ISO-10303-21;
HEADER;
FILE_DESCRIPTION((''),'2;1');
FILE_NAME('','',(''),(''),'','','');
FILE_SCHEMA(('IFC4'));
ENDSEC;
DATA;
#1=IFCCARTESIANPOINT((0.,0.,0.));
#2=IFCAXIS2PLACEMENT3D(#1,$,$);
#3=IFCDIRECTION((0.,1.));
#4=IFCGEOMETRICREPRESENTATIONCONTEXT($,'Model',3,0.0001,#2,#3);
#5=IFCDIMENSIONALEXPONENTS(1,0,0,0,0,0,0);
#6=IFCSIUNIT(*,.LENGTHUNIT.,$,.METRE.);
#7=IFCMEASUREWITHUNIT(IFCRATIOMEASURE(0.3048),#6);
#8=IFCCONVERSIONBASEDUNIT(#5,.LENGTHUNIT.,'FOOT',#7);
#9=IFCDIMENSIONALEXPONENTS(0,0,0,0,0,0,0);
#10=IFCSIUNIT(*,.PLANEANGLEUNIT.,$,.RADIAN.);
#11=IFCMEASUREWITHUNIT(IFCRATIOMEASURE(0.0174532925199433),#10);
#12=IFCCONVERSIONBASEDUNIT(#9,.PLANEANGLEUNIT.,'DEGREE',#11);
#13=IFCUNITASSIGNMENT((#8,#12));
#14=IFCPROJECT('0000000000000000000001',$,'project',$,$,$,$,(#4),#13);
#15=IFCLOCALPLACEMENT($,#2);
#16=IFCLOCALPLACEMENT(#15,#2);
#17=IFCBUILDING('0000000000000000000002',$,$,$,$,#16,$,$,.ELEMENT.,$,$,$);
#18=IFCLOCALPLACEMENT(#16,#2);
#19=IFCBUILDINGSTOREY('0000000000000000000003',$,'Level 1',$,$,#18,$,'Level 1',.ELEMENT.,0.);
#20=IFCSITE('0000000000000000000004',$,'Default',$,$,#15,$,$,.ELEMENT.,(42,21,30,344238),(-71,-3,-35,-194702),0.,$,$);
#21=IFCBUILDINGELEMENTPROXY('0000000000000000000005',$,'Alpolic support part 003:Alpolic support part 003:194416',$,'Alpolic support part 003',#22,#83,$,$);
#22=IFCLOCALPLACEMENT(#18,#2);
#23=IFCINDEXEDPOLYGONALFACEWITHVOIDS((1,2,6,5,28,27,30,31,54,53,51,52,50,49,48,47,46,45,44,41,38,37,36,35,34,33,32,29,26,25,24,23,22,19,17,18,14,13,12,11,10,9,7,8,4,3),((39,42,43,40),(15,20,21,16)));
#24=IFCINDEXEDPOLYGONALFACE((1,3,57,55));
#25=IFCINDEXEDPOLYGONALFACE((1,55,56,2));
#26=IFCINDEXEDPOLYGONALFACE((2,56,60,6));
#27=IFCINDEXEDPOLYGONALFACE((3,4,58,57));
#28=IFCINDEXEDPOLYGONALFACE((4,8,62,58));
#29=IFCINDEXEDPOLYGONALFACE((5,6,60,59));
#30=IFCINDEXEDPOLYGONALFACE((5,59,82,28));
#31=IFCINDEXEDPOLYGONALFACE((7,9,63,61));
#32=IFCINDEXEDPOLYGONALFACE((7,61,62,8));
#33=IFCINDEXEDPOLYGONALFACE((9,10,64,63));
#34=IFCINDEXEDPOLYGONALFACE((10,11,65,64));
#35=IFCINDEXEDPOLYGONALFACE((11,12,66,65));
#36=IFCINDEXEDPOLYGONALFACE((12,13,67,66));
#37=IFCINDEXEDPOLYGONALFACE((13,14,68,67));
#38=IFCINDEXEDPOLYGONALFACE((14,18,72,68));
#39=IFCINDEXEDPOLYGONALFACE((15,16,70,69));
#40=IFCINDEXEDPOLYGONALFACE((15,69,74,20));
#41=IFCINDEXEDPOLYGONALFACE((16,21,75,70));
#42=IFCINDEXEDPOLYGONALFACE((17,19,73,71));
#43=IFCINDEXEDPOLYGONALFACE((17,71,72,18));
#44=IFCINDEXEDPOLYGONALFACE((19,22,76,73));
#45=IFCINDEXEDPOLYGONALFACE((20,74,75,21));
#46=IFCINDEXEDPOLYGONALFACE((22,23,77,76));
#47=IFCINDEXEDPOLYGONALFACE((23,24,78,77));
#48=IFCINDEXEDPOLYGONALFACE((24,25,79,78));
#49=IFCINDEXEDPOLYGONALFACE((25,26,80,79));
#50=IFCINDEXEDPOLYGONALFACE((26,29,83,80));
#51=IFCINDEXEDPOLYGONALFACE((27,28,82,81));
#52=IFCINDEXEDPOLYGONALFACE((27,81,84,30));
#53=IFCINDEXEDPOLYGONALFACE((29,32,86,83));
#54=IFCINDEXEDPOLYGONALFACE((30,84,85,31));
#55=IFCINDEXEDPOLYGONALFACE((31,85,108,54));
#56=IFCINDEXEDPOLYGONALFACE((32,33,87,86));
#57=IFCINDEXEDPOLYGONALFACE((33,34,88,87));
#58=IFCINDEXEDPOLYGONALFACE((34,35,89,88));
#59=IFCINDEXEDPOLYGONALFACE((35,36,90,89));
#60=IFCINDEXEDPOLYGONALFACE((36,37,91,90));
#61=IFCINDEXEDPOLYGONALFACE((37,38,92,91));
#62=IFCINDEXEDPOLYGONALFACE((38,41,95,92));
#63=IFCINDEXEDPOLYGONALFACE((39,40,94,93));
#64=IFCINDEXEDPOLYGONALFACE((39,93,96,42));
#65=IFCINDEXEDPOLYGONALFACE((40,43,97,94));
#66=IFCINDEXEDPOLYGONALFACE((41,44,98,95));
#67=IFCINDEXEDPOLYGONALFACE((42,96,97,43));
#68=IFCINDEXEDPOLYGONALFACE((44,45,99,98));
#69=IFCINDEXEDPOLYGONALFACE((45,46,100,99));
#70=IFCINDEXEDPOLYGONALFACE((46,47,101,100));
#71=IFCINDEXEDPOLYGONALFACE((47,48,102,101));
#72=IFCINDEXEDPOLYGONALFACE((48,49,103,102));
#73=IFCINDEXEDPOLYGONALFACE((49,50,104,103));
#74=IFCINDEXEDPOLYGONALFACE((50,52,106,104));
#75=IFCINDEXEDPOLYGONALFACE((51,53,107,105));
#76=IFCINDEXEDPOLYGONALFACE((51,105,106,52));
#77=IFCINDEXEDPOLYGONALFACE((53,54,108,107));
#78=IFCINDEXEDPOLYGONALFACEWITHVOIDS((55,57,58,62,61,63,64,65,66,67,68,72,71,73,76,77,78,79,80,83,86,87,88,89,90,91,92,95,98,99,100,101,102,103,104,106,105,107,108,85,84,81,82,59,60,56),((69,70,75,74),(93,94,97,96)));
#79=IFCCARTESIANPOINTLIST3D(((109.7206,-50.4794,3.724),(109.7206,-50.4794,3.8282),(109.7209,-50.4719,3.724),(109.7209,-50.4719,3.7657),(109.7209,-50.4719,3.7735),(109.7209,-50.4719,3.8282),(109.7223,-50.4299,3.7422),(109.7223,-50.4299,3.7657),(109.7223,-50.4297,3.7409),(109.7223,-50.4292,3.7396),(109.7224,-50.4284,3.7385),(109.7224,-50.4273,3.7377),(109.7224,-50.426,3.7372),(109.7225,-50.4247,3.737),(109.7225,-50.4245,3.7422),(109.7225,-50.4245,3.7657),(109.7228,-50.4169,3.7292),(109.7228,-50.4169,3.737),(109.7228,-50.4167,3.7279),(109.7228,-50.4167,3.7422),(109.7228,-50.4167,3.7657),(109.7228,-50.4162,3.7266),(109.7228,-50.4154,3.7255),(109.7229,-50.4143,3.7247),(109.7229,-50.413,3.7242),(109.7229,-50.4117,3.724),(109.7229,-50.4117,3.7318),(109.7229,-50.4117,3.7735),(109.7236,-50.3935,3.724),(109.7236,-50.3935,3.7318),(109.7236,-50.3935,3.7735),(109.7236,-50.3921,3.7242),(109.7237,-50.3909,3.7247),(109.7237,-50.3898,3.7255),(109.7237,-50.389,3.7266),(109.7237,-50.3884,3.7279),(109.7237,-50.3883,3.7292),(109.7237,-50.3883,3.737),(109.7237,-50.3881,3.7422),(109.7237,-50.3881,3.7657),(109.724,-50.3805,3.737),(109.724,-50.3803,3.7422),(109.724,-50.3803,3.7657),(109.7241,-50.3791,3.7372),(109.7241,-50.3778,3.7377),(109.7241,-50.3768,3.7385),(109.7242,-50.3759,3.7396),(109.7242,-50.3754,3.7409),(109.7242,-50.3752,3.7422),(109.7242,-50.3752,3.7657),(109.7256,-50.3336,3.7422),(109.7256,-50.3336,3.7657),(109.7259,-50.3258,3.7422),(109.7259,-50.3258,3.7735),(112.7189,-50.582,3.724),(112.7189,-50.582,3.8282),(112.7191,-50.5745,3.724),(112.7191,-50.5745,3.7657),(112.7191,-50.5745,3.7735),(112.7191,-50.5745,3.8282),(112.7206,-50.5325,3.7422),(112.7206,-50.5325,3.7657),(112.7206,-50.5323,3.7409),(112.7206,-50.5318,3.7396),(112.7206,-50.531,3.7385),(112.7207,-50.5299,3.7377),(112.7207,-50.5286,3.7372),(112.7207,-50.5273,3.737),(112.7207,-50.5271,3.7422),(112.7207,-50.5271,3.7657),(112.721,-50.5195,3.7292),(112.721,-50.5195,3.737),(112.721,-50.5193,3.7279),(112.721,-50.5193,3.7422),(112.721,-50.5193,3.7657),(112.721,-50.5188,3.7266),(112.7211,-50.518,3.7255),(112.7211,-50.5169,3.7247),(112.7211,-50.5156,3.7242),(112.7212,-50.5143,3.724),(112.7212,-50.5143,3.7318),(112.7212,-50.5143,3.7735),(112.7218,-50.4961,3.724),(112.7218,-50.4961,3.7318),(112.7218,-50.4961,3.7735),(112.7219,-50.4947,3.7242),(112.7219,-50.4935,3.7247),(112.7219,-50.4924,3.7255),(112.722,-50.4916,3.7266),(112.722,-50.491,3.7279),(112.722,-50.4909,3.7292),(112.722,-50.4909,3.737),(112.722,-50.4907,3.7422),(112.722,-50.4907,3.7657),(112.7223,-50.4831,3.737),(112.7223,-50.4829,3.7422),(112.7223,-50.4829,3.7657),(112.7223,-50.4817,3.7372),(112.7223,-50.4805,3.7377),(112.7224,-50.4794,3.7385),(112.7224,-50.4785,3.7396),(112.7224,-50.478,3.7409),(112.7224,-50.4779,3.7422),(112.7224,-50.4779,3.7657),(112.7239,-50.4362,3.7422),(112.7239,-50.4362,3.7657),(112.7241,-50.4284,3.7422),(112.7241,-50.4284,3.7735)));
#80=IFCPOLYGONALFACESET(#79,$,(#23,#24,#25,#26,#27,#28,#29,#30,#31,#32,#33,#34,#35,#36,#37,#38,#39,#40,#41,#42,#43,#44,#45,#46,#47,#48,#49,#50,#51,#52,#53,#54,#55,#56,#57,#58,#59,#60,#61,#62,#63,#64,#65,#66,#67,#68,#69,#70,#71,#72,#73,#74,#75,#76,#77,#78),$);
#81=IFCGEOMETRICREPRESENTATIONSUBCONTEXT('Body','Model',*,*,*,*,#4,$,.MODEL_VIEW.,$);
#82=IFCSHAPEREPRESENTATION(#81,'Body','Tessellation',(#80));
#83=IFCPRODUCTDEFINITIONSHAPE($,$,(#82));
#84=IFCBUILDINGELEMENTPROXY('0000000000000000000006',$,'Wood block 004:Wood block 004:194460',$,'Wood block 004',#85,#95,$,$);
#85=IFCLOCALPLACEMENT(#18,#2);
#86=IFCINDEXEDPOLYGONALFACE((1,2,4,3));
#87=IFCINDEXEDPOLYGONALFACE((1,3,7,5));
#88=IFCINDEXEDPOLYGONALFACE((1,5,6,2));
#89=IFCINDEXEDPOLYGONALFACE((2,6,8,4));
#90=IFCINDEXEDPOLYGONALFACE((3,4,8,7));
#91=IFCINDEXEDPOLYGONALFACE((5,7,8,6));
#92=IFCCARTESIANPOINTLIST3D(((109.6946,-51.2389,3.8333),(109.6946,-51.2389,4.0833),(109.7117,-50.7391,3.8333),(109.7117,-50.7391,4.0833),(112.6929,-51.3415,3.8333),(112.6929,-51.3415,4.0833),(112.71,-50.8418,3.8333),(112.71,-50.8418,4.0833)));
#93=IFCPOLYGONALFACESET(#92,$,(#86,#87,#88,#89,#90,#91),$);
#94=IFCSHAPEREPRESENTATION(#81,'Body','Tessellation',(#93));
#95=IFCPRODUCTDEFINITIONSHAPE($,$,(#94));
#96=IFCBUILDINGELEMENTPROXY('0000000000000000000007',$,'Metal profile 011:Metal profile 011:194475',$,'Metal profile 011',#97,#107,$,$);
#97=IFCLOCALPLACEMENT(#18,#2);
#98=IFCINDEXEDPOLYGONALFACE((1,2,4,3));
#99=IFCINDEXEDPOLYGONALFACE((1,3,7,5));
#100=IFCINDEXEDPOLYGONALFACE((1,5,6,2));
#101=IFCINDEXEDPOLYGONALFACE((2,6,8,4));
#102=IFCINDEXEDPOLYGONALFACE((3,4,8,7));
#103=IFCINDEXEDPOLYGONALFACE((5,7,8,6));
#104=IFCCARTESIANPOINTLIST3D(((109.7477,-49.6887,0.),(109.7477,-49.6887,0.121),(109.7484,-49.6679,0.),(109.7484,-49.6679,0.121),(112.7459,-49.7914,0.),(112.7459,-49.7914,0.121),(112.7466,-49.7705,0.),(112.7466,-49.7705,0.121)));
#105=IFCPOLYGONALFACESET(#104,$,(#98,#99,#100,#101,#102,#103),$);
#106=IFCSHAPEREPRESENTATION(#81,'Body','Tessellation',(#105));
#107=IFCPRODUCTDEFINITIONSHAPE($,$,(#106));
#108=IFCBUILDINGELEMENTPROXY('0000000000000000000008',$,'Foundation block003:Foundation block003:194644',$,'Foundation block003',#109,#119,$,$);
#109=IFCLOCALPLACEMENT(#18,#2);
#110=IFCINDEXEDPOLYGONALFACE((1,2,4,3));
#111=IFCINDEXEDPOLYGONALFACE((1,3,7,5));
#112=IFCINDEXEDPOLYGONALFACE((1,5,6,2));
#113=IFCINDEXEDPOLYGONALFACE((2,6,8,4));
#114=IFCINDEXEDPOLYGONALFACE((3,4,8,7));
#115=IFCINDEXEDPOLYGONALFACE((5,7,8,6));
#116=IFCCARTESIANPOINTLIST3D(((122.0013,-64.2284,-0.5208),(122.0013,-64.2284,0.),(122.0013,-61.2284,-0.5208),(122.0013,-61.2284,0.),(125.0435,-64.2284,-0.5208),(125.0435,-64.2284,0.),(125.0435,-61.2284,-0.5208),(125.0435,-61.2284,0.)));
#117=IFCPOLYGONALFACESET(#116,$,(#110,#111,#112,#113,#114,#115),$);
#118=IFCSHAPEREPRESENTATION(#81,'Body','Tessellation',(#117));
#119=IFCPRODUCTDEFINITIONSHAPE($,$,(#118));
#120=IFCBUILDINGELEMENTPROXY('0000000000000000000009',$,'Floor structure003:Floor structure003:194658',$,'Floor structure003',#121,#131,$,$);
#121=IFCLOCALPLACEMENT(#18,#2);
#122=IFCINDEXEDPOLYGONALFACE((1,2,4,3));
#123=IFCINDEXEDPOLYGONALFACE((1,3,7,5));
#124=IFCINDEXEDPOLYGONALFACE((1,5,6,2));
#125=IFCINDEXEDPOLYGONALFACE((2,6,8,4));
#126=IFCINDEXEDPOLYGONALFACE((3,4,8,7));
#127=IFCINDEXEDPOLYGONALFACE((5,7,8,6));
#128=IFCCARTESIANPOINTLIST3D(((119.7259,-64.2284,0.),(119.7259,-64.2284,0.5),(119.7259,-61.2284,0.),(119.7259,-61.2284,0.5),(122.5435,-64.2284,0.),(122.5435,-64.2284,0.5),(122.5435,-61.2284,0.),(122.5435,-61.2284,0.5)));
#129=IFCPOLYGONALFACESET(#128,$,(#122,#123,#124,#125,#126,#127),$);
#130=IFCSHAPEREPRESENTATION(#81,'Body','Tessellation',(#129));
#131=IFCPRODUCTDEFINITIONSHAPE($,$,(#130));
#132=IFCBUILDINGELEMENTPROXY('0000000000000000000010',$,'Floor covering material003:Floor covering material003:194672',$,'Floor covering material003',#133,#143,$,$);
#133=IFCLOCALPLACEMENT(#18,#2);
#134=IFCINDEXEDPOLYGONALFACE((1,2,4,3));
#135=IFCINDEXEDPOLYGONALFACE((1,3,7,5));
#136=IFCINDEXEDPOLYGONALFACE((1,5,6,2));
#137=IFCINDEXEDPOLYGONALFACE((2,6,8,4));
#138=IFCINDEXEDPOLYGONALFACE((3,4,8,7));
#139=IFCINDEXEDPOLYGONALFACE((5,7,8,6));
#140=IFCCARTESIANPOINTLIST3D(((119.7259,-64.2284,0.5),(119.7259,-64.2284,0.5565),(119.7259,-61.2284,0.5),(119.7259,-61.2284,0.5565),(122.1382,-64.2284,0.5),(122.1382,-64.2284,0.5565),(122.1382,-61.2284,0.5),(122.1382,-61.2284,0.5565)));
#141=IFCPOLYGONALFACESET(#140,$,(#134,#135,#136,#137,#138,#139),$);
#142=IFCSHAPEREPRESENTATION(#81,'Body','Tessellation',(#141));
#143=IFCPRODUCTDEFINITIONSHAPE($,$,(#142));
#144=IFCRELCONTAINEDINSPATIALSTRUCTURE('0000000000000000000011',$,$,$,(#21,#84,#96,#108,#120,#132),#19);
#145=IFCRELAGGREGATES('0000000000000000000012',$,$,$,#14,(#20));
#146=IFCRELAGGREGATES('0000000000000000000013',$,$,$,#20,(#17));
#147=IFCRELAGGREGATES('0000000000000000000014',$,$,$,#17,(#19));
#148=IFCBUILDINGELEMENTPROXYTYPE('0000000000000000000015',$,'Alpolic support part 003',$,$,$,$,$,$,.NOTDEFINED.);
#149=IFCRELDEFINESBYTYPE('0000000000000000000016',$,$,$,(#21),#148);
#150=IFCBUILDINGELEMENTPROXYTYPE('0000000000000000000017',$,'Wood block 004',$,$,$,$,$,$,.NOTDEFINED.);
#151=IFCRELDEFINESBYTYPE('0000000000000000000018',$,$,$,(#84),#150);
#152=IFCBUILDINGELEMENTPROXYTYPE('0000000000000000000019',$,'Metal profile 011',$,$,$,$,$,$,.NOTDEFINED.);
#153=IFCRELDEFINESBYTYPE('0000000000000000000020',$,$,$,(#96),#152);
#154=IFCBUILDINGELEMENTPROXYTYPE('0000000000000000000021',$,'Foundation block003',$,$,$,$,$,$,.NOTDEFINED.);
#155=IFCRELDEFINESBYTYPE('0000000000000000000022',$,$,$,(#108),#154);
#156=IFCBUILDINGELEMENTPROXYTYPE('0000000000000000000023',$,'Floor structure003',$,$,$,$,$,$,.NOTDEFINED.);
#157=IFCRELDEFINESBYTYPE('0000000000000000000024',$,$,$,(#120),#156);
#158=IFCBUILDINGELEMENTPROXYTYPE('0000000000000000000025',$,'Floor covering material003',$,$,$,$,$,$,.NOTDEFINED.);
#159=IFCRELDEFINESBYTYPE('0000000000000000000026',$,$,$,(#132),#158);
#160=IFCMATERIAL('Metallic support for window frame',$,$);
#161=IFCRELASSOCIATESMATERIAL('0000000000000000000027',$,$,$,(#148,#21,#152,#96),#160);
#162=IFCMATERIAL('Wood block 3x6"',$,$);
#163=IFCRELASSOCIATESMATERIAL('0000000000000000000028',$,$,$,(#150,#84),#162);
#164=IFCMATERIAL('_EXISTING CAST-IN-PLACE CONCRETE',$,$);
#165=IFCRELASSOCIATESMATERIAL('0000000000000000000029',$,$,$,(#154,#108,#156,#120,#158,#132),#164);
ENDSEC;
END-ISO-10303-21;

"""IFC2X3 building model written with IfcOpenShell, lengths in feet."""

from ifc_helpers import new_model, entity, si_unit, converted_unit, direction, frame, frame_2d, origin, origin_2d_with_axis, place, context, subcontext, project, spatial, polyline, circle_curve, parameter, trimmed, segment, composite_curve, rectangle, outline, extrude, source, transform, mapped, material, type_object, type_shapes, element, save


model = new_model("IFC2X3")

# Units and contexts
model_context = context("Model", 3, precision=0.0001, world=origin(), true_north=direction((0.0, 1.0)))
body_context = subcontext(model_context, "Body", "Model", "MODEL_VIEW")
ifc_project = project(units=[converted_unit("LENGTHUNIT", "FOOT", entity("IfcRatioMeasure", 0.3048), si_unit("LENGTHUNIT", "METRE"), dimensions=[1, 0, 0, 0, 0, 0, 0]), converted_unit("PLANEANGLEUNIT", "DEGREE", entity("IfcRatioMeasure", 0.0174532925199433), si_unit("PLANEANGLEUNIT", "RADIAN"), dimensions=[0, 0, 0, 0, 0, 0, 0])], contexts=[model_context])

# Site, building, storey
site_placement = place(None, origin())
site = spatial("IfcSite", under=ifc_project, at=site_placement, Name="Default", CompositionType="ELEMENT", RefLatitude=(42, 21, 30, 344238), RefLongitude=(-71, -3, -35, -194702), RefElevation=0.0)
building_placement = place(site_placement, origin())
building = spatial("IfcBuilding", under=site, at=building_placement, CompositionType="ELEMENT")
storey_placement = place(building_placement, origin())
storey = spatial("IfcBuildingStorey", under=building, at=storey_placement, Name="Level 1", LongName="Level 1", CompositionType="ELEMENT", Elevation=0.0)

# Building element proxies
ifc_material_1 = material(Name="Metallic support for window frame")
building_element_proxy_type_1 = type_object("IfcBuildingElementProxyType", Name="Alpolic support part 003", PredefinedType="NOTDEFINED", material=ifc_material_1)
shared_shape_1 = source(origin(), body_context, "Body", "SweptSolid", [
    extrude(outline(composite_curve([segment(trimmed(circle_curve(frame_2d((-0.0096, 0.0275), x_axis=(0.0, -1.0)), 0.0052), [parameter(180.0)], [parameter(270.0)], True, "PARAMETER"), True, "CONTINUOUS"), segment(polyline([(-0.0148, 0.0275), (-0.0148, 0.0197)]), True, "CONTINUOUS"), segment(polyline([(-0.0148, 0.0197), (-0.0226, 0.0197)]), True, "CONTINUOUS"), segment(trimmed(circle_curve(frame_2d((-0.0226, 0.0145), x_axis=(0.0, -1.0)), 0.0052), [parameter(180.0)], [parameter(270.0)], True, "PARAMETER"), True, "CONTINUOUS"), segment(polyline([(-0.0278, 0.0145), (-0.0278, -0.0038)]), True, "CONTINUOUS"), segment(trimmed(circle_curve(frame_2d((-0.0226, -0.0038), x_axis=(0.0, -1.0)), 0.0052), [parameter(270.0)], [parameter(0.0)], True, "PARAMETER"), True, "CONTINUOUS"), segment(polyline([(-0.0226, -0.009), (-0.0148, -0.009)]), True, "CONTINUOUS"), segment(polyline([(-0.0148, -0.009), (-0.0148, -0.0168)]), True, "CONTINUOUS"), segment(trimmed(circle_curve(frame_2d((-0.0096, -0.0168), x_axis=(0.0, -1.0)), 0.0052), [parameter(270.0)], [parameter(0.0)], True, "PARAMETER"), True, "CONTINUOUS"), segment(polyline([(-0.0096, -0.022), (0.0138, -0.022)]), True, "CONTINUOUS"), segment(polyline([(0.0138, -0.022), (0.0138, -0.064)]), True, "CONTINUOUS"), segment(polyline([(0.0138, -0.064), (-0.0278, -0.064)]), True, "CONTINUOUS"), segment(polyline([(-0.0278, -0.064), (-0.0278, -0.0715)]), True, "CONTINUOUS"), segment(polyline([(-0.0278, -0.0715), (0.0763, -0.0715)]), True, "CONTINUOUS"), segment(polyline([(0.0763, -0.0715), (0.0763, -0.064)]), True, "CONTINUOUS"), segment(polyline([(0.0763, -0.064), (0.0216, -0.064)]), True, "CONTINUOUS"), segment(polyline([(0.0216, -0.064), (0.0216, -0.0038)]), True, "CONTINUOUS"), segment(polyline([(0.0216, -0.0038), (-0.02, -0.0038)]), True, "CONTINUOUS"), segment(polyline([(-0.02, -0.0038), (-0.02, 0.0145)]), True, "CONTINUOUS"), segment(polyline([(-0.02, 0.0145), (0.0216, 0.0145)]), True, "CONTINUOUS"), segment(polyline([(0.0216, 0.0145), (0.0216, 0.0822)]), True, "CONTINUOUS"), segment(polyline([(0.0216, 0.0822), (-0.0096, 0.0822)]), True, "CONTINUOUS"), segment(polyline([(-0.0096, 0.0822), (-0.0096, 0.0744)]), True, "CONTINUOUS"), segment(polyline([(-0.0096, 0.0744), (0.0138, 0.0744)]), True, "CONTINUOUS"), segment(polyline([(0.0138, 0.0744), (0.0138, 0.0327)]), True, "CONTINUOUS"), segment(polyline([(0.0138, 0.0327), (-0.0096, 0.0327)]), True, "CONTINUOUS")], self_intersect=False), holes=[polyline([(0.0138, 0.0277), (0.0138, 0.0198), (-0.0096, 0.0198), (-0.0096, 0.0277), (0.0138, 0.0277)]), polyline([(-0.0096, -0.0166), (-0.0096, -0.0088), (0.0138, -0.0088), (0.0138, -0.0166), (-0.0096, -0.0166)])]), frame((109.7231, -50.4079, 3.7518), z_axis=(-0.999415, 0.034202, 0.0), x_axis=(0.0, 0.0, 1.0)), (0.0, 0.0, -1.0), 3.0),
])
type_shapes(building_element_proxy_type_1, [shared_shape_1])
proxy_1_placement = place(storey_placement, origin())
element("IfcBuildingElementProxy", 1, at=proxy_1_placement, inside=storey, type_object=building_element_proxy_type_1, material=ifc_material_1, Name="Alpolic support part 003:Alpolic support part 003:194416", ObjectType="Alpolic support part 003", context=body_context, shape_type="MappedRepresentation", body=[
    mapped(shared_shape_1, transform((0.0, 0.0, 0.0), scale=1.0)),
])
ifc_material_2 = material(Name="Wood block 3x6\"")
building_element_proxy_type_2 = type_object("IfcBuildingElementProxyType", Name="Wood block 004", PredefinedType="NOTDEFINED", material=ifc_material_2)
shared_shape_2 = source(origin(), body_context, "Body", "SweptSolid", [
    extrude(rectangle(XDim=3.0, YDim=0.5, at=frame_2d((0.0, 0.0), x_axis=(1.0, 0.0))), frame((111.2023, -51.0403, 3.8333), z_axis=(0.0, 0.0, 1.0), x_axis=(0.999415, -0.034202, 0.0)), (0.0, 0.0, 1.0), 0.25),
])
type_shapes(building_element_proxy_type_2, [shared_shape_2])
proxy_2_placement = place(storey_placement, origin())
element("IfcBuildingElementProxy", 2, at=proxy_2_placement, inside=storey, type_object=building_element_proxy_type_2, material=ifc_material_2, Name="Wood block 004:Wood block 004:194460", ObjectType="Wood block 004", context=body_context, shape_type="MappedRepresentation", body=[
    mapped(shared_shape_2, transform((0.0, 0.0, 0.0), scale=1.0)),
])
building_element_proxy_type_3 = type_object("IfcBuildingElementProxyType", Name="Metal profile 011", PredefinedType="NOTDEFINED", material=ifc_material_1)
shared_shape_3 = source(origin(), body_context, "Body", "SweptSolid", [
    extrude(rectangle(XDim=3.0, YDim=0.0208, at=frame_2d((0.0, 0.0), x_axis=(1.0, 0.0))), frame((111.2472, -49.7296, 0.0), z_axis=(0.0, 0.0, 1.0), x_axis=(0.999415, -0.034202, 0.0)), (0.0, 0.0, 1.0), 0.121),
])
type_shapes(building_element_proxy_type_3, [shared_shape_3])
proxy_3_placement = place(storey_placement, origin())
element("IfcBuildingElementProxy", 3, at=proxy_3_placement, inside=storey, type_object=building_element_proxy_type_3, material=ifc_material_1, Name="Metal profile 011:Metal profile 011:194475", ObjectType="Metal profile 011", context=body_context, shape_type="MappedRepresentation", body=[
    mapped(shared_shape_3, transform((0.0, 0.0, 0.0), scale=1.0)),
])
ifc_material_3 = material(Name="_EXISTING CAST-IN-PLACE CONCRETE")
building_element_proxy_type_4 = type_object("IfcBuildingElementProxyType", Name="Foundation block003", PredefinedType="NOTDEFINED", material=ifc_material_3)
shared_shape_4 = source(origin(), body_context, "Body", "SweptSolid", [
    extrude(rectangle(XDim=3.0, YDim=3.0422, at=origin_2d_with_axis()), frame((123.5224, -62.7284, -0.5208), z_axis=(0.0, 0.0, 1.0), x_axis=(0.0, 1.0, 0.0)), (0.0, 0.0, 1.0), 0.5208),
])
type_shapes(building_element_proxy_type_4, [shared_shape_4])
proxy_4_placement = place(storey_placement, origin())
element("IfcBuildingElementProxy", 4, at=proxy_4_placement, inside=storey, type_object=building_element_proxy_type_4, material=ifc_material_3, Name="Foundation block003:Foundation block003:194644", ObjectType="Foundation block003", context=body_context, shape_type="MappedRepresentation", body=[
    mapped(shared_shape_4, transform((0.0, 0.0, 0.0), scale=1.0)),
])
building_element_proxy_type_5 = type_object("IfcBuildingElementProxyType", Name="Floor structure003", PredefinedType="NOTDEFINED", material=ifc_material_3)
shared_shape_5 = source(origin(), body_context, "Body", "SweptSolid", [
    extrude(rectangle(XDim=3.0, YDim=2.8177, at=origin_2d_with_axis()), frame((121.1347, -62.7284, 0.0), z_axis=(0.0, 0.0, 1.0), x_axis=(0.0, 1.0, 0.0)), (0.0, 0.0, 1.0), 0.5),
])
type_shapes(building_element_proxy_type_5, [shared_shape_5])
proxy_5_placement = place(storey_placement, origin())
element("IfcBuildingElementProxy", 5, at=proxy_5_placement, inside=storey, type_object=building_element_proxy_type_5, material=ifc_material_3, Name="Floor structure003:Floor structure003:194658", ObjectType="Floor structure003", context=body_context, shape_type="MappedRepresentation", body=[
    mapped(shared_shape_5, transform((0.0, 0.0, 0.0), scale=1.0)),
])
building_element_proxy_type_6 = type_object("IfcBuildingElementProxyType", Name="Floor covering material003", PredefinedType="NOTDEFINED", material=ifc_material_3)
shared_shape_6 = source(origin(), body_context, "Body", "SweptSolid", [
    extrude(rectangle(XDim=3.0, YDim=2.4124, at=origin_2d_with_axis()), frame((120.9321, -62.7284, 0.5), z_axis=(0.0, 0.0, 1.0), x_axis=(0.0, 1.0, 0.0)), (0.0, 0.0, 1.0), 0.0565),
])
type_shapes(building_element_proxy_type_6, [shared_shape_6])
proxy_6_placement = place(storey_placement, origin())
element("IfcBuildingElementProxy", 6, at=proxy_6_placement, inside=storey, type_object=building_element_proxy_type_6, material=ifc_material_3, Name="Floor covering material003:Floor covering material003:194672", ObjectType="Floor covering material003", context=body_context, shape_type="MappedRepresentation", body=[
    mapped(shared_shape_6, transform((0.0, 0.0, 0.0), scale=1.0)),
])

save(model, "model.ifc")
